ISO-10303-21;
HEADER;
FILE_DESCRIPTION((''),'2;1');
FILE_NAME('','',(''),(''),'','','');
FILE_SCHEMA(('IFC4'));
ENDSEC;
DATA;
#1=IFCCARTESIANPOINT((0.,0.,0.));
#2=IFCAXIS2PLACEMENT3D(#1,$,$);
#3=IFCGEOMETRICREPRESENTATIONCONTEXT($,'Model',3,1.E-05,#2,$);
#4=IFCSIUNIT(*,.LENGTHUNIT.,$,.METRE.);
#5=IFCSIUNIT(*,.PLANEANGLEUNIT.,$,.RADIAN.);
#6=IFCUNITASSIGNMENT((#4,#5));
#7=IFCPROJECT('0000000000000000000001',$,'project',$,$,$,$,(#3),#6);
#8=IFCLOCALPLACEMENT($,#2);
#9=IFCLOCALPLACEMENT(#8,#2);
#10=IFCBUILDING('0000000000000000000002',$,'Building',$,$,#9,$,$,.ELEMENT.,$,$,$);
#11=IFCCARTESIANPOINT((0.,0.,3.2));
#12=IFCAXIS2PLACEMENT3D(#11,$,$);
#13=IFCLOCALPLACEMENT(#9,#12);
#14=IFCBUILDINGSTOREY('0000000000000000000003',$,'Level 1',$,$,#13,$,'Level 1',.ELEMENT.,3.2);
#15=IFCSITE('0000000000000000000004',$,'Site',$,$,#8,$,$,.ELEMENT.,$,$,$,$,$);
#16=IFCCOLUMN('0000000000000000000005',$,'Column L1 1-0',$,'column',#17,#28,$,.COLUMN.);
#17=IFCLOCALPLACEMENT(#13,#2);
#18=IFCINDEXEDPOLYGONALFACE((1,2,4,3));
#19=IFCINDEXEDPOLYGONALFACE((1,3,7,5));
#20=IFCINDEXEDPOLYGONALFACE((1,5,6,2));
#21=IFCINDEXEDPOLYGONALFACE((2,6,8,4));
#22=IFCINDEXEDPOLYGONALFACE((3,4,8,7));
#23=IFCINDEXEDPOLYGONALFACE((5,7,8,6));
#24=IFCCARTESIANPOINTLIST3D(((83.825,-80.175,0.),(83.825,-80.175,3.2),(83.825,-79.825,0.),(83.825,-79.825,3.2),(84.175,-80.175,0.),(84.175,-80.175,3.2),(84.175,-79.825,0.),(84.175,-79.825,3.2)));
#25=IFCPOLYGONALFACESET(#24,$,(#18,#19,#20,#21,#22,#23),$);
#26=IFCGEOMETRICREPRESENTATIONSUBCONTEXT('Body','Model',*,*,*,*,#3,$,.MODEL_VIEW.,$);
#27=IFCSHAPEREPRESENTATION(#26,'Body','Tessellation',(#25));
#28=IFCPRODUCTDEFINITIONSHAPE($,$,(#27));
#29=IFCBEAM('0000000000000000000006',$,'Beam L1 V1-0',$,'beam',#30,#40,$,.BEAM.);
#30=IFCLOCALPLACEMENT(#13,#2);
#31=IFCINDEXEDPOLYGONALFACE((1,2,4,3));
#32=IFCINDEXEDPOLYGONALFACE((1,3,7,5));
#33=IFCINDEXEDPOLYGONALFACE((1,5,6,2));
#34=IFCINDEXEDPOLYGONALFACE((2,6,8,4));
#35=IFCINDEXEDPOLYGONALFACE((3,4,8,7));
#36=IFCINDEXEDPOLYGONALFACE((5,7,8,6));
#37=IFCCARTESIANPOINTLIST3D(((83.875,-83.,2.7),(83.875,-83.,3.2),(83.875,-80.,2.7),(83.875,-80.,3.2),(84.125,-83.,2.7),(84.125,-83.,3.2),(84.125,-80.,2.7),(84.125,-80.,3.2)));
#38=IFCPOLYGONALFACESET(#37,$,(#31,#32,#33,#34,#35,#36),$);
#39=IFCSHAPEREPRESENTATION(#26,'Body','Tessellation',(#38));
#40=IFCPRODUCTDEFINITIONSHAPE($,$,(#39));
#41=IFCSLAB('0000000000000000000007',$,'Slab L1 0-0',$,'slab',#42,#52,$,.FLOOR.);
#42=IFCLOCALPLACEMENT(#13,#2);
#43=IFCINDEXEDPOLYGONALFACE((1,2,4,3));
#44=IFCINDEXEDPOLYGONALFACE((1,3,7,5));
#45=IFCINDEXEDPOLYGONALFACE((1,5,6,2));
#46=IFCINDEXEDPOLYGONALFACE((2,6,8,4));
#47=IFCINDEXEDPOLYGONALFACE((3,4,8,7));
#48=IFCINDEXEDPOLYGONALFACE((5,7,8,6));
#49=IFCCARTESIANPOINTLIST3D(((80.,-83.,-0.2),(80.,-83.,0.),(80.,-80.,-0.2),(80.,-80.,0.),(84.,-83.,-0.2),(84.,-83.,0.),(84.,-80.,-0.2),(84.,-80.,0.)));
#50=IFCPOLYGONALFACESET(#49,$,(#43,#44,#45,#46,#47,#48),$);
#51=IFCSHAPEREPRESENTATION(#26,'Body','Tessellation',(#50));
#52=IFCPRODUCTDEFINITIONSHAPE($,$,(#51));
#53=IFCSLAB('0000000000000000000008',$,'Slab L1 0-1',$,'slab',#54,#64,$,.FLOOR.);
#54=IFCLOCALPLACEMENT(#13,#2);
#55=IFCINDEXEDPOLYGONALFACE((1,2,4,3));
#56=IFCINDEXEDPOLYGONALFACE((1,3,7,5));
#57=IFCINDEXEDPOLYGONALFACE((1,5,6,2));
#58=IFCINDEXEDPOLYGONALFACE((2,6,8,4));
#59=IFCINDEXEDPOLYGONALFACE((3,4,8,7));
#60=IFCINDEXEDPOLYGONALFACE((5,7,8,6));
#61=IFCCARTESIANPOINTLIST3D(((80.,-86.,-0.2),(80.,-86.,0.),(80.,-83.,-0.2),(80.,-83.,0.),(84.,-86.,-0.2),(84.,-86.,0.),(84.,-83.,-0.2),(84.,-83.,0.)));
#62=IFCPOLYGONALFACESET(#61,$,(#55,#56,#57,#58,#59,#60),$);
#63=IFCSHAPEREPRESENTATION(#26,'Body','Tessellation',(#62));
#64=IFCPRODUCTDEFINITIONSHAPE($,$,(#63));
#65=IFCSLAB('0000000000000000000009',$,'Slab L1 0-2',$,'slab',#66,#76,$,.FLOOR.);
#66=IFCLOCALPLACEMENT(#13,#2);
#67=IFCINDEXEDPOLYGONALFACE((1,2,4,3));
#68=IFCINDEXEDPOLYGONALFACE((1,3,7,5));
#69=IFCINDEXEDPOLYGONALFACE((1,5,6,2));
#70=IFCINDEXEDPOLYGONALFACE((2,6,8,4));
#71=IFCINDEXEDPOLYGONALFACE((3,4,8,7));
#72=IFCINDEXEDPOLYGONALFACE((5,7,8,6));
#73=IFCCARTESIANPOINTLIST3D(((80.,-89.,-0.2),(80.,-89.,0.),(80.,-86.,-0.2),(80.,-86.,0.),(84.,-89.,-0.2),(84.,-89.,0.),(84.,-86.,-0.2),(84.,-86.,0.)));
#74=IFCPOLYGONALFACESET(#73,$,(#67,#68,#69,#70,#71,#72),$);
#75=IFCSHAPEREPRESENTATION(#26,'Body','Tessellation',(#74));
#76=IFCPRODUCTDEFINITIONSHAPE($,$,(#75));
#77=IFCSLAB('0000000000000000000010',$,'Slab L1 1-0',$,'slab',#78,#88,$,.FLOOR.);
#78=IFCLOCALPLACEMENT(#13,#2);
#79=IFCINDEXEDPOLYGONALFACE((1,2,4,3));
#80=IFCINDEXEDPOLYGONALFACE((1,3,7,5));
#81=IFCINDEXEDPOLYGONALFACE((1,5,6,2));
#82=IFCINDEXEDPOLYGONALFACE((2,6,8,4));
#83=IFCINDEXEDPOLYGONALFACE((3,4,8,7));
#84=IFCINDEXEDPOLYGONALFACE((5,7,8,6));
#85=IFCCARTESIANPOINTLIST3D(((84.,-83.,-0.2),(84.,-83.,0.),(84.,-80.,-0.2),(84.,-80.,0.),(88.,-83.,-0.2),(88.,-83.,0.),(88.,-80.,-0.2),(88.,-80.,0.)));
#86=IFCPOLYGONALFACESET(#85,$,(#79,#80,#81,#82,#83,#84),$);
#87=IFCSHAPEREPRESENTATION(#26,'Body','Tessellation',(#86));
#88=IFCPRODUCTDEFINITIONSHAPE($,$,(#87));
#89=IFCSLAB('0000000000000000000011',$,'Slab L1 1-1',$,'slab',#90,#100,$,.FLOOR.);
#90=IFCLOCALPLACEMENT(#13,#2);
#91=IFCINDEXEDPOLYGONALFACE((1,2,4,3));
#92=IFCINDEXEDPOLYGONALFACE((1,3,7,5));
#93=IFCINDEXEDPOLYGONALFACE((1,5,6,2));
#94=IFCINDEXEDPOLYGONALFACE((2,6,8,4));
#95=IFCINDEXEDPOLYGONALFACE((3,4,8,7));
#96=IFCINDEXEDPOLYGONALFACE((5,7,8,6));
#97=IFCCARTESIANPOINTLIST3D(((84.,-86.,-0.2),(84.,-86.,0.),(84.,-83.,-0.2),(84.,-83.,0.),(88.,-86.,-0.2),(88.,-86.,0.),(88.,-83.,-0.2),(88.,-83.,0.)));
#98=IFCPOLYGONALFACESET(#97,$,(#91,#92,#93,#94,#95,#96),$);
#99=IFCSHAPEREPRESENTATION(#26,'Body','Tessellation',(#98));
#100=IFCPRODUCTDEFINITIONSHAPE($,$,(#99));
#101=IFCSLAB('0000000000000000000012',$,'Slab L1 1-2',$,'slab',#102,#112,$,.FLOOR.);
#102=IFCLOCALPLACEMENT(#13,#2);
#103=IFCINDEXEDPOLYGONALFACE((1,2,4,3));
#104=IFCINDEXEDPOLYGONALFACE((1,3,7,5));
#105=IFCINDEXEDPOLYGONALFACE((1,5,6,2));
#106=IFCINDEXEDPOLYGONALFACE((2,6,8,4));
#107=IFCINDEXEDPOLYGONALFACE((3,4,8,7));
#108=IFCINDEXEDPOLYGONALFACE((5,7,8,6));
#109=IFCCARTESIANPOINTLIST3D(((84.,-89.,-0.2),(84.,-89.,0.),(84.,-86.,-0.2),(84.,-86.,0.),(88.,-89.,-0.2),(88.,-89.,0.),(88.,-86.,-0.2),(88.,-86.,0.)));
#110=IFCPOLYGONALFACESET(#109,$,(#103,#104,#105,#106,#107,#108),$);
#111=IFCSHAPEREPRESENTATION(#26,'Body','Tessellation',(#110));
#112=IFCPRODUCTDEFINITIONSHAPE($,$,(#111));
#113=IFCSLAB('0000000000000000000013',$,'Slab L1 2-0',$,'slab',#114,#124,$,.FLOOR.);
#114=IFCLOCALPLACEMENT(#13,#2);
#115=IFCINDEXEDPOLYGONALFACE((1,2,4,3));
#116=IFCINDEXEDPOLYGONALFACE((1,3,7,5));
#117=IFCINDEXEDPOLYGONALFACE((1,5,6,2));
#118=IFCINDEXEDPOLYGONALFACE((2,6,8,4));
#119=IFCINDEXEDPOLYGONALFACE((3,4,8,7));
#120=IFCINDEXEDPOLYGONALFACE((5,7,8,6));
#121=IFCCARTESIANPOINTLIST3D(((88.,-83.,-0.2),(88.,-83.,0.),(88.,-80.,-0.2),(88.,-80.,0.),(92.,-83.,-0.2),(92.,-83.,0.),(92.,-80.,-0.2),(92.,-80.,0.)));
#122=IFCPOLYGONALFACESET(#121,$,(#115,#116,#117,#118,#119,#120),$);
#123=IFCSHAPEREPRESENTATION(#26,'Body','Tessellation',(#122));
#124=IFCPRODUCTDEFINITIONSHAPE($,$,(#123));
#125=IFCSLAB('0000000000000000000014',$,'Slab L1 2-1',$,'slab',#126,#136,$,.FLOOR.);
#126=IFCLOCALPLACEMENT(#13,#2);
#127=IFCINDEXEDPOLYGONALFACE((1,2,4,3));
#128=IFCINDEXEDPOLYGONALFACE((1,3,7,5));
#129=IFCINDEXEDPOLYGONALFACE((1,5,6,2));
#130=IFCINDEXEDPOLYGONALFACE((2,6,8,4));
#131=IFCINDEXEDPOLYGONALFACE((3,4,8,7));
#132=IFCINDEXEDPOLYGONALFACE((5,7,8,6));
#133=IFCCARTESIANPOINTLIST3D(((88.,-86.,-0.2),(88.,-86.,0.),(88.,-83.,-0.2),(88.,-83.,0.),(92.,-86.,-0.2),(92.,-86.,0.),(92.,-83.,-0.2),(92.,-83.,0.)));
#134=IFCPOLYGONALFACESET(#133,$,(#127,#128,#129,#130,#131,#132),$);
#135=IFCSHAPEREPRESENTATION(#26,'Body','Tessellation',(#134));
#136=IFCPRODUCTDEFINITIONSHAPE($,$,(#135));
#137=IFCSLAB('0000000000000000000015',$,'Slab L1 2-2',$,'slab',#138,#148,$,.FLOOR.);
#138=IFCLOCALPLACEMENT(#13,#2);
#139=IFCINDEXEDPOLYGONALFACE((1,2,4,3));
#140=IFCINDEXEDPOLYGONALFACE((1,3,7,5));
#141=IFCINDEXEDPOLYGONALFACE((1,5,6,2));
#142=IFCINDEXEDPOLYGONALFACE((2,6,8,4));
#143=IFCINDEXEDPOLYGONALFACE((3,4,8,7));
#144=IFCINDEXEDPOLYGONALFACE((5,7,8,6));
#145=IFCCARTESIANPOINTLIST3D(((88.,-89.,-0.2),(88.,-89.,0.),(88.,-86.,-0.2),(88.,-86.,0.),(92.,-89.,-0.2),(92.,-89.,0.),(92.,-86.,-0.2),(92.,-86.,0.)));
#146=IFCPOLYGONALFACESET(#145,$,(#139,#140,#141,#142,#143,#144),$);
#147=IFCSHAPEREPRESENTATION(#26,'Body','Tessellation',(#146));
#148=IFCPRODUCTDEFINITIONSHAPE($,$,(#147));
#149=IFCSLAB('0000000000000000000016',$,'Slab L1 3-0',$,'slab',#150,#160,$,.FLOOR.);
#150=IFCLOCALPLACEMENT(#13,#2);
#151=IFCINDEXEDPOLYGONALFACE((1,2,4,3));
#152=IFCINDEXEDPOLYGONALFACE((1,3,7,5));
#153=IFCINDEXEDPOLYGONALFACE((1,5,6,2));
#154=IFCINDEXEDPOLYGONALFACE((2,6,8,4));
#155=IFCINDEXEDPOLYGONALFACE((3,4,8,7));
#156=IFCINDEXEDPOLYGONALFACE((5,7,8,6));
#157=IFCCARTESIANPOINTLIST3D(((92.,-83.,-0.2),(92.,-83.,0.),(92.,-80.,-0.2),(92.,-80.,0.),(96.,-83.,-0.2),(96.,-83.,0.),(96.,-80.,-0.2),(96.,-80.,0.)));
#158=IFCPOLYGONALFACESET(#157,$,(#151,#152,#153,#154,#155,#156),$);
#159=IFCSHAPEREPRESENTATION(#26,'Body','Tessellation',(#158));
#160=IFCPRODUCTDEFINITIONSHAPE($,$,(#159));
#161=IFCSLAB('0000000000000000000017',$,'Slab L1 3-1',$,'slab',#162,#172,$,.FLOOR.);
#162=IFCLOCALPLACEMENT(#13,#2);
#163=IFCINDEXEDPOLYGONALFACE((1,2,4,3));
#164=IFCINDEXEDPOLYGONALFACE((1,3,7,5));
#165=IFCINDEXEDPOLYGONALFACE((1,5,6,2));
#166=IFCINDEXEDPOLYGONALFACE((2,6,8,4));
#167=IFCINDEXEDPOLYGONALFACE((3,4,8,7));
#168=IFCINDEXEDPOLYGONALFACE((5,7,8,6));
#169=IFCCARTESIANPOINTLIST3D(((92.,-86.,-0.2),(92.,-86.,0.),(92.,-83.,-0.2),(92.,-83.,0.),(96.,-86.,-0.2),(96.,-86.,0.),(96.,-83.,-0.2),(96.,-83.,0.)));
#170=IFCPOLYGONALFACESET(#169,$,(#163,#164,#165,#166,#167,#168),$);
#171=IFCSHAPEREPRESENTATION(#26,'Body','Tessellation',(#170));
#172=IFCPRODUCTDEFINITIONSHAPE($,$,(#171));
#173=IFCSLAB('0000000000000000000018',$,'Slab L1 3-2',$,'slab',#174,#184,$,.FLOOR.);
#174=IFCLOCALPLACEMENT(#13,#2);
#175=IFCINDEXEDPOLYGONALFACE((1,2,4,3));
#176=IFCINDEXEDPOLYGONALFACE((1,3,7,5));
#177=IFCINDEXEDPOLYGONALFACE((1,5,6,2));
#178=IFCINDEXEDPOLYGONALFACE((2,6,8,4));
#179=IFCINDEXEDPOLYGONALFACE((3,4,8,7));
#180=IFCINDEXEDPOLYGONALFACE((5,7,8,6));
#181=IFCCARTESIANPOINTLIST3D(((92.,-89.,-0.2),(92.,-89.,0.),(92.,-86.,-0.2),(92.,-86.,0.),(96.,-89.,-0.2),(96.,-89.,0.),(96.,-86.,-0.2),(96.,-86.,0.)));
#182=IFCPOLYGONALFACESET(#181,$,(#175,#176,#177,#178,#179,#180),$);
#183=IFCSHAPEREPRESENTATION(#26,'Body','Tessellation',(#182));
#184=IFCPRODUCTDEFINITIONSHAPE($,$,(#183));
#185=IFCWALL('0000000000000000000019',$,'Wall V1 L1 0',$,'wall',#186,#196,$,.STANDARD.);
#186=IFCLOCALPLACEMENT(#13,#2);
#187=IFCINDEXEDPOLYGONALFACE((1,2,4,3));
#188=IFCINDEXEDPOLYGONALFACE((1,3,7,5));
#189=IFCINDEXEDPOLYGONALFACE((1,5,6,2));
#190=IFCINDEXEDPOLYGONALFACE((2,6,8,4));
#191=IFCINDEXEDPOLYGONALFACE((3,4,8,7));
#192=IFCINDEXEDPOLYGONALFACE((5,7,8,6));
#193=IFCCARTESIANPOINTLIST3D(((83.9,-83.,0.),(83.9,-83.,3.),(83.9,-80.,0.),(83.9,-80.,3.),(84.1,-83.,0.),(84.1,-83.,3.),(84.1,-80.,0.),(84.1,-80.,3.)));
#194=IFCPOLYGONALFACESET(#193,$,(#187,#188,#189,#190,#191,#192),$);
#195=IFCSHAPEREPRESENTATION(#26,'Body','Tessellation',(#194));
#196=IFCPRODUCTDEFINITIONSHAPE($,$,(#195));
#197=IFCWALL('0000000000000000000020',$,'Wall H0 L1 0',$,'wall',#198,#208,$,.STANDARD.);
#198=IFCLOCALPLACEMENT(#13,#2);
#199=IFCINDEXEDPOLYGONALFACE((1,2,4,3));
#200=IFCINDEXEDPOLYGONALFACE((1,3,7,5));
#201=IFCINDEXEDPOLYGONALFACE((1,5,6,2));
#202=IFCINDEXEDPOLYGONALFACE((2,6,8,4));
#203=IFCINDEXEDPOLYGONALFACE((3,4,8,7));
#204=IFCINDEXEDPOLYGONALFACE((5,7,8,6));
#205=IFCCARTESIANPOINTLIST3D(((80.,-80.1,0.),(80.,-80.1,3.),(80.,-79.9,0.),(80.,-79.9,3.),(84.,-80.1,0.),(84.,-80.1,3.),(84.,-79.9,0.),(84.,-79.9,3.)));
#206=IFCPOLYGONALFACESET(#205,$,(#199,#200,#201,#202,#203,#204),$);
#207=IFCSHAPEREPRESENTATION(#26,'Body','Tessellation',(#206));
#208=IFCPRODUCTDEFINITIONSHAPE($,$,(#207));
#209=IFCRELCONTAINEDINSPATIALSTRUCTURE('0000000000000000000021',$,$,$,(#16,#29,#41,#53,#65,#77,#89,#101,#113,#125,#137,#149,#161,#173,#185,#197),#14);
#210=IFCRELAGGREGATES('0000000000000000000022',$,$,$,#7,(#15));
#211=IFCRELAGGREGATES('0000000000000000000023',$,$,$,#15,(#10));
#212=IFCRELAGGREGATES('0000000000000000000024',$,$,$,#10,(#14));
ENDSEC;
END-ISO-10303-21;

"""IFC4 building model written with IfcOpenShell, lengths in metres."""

from ifc_helpers import new_model, si_unit, frame, frame_2d, origin, origin_2d, place, context, subcontext, project, spatial, polyline, rectangle, outline, extrude, element, save


model = new_model("IFC4")

# Units and contexts
model_context = context("Model", 3, precision=1e-05, world=origin())
body_context = subcontext(model_context, "Body", "Model", "MODEL_VIEW")
ifc_project = project(units=[si_unit("LENGTHUNIT", "METRE"), si_unit("PLANEANGLEUNIT", "RADIAN")], contexts=[model_context])

# Site, building, storey
site_placement = place(None, origin())
site = spatial("IfcSite", under=ifc_project, at=site_placement, Name="Site", CompositionType="ELEMENT")
building_placement = place(site_placement, origin())
building = spatial("IfcBuilding", under=site, at=building_placement, Name="Building", CompositionType="ELEMENT")
storey_placement = place(building_placement, frame((0.0, 0.0, 3.2)))
storey = spatial("IfcBuildingStorey", under=building, at=storey_placement, Name="Level 1", LongName="Level 1", CompositionType="ELEMENT", Elevation=3.2)

# Column
column_placement = place(storey_placement, frame((84.0, -80.0, 0.0)))
element("IfcColumn", 1, at=column_placement, inside=storey, Name="Column L1 1-0", ObjectType="column", PredefinedType="COLUMN", context=body_context, shape_type="SweptSolid", body=[
    extrude(rectangle(XDim=0.35, YDim=0.35, at=origin_2d()), origin(), (0.0, 0.0, 1.0), 3.2),
])

# Beam
beam_placement = place(storey_placement, frame((84.0, -80.0, 2.95), z_axis=(0.0, -1.0, 0.0), x_axis=(0.0, 0.0, 1.0)))
element("IfcBeam", 2, at=beam_placement, inside=storey, Name="Beam L1 V1-0", ObjectType="beam", PredefinedType="BEAM", context=body_context, shape_type="SweptSolid", body=[
    extrude(rectangle(XDim=0.5, YDim=0.25, at=origin_2d()), origin(), (0.0, 0.0, 1.0), 3.0),
])

# Slabs
slab_1_placement = place(storey_placement, frame((0.0, 0.0, -0.2)))
element("IfcSlab", 3, at=slab_1_placement, inside=storey, Name="Slab L1 0-0", ObjectType="slab", PredefinedType="FLOOR", context=body_context, shape_type="SweptSolid", body=[
    extrude(outline(polyline([(80.0, -83.0), (84.0, -83.0), (84.0, -80.0), (80.0, -80.0), (80.0, -83.0)])), origin(), (0.0, 0.0, 1.0), 0.2),
])
slab_2_placement = place(storey_placement, frame((0.0, 0.0, -0.2)))
element("IfcSlab", 4, at=slab_2_placement, inside=storey, Name="Slab L1 0-1", ObjectType="slab", PredefinedType="FLOOR", context=body_context, shape_type="SweptSolid", body=[
    extrude(outline(polyline([(80.0, -86.0), (84.0, -86.0), (84.0, -83.0), (80.0, -83.0), (80.0, -86.0)])), origin(), (0.0, 0.0, 1.0), 0.2),
])
slab_3_placement = place(storey_placement, frame((0.0, 0.0, -0.2)))
element("IfcSlab", 5, at=slab_3_placement, inside=storey, Name="Slab L1 0-2", ObjectType="slab", PredefinedType="FLOOR", context=body_context, shape_type="SweptSolid", body=[
    extrude(outline(polyline([(80.0, -89.0), (84.0, -89.0), (84.0, -86.0), (80.0, -86.0), (80.0, -89.0)])), origin(), (0.0, 0.0, 1.0), 0.2),
])
slab_4_placement = place(storey_placement, frame((0.0, 0.0, -0.2)))
element("IfcSlab", 6, at=slab_4_placement, inside=storey, Name="Slab L1 1-0", ObjectType="slab", PredefinedType="FLOOR", context=body_context, shape_type="SweptSolid", body=[
    extrude(outline(polyline([(84.0, -83.0), (88.0, -83.0), (88.0, -80.0), (84.0, -80.0), (84.0, -83.0)])), origin(), (0.0, 0.0, 1.0), 0.2),
])
slab_5_placement = place(storey_placement, frame((0.0, 0.0, -0.2)))
element("IfcSlab", 7, at=slab_5_placement, inside=storey, Name="Slab L1 1-1", ObjectType="slab", PredefinedType="FLOOR", context=body_context, shape_type="SweptSolid", body=[
    extrude(outline(polyline([(84.0, -86.0), (88.0, -86.0), (88.0, -83.0), (84.0, -83.0), (84.0, -86.0)])), origin(), (0.0, 0.0, 1.0), 0.2),
])
slab_6_placement = place(storey_placement, frame((0.0, 0.0, -0.2)))
element("IfcSlab", 8, at=slab_6_placement, inside=storey, Name="Slab L1 1-2", ObjectType="slab", PredefinedType="FLOOR", context=body_context, shape_type="SweptSolid", body=[
    extrude(outline(polyline([(84.0, -89.0), (88.0, -89.0), (88.0, -86.0), (84.0, -86.0), (84.0, -89.0)])), origin(), (0.0, 0.0, 1.0), 0.2),
])
slab_7_placement = place(storey_placement, frame((0.0, 0.0, -0.2)))
element("IfcSlab", 9, at=slab_7_placement, inside=storey, Name="Slab L1 2-0", ObjectType="slab", PredefinedType="FLOOR", context=body_context, shape_type="SweptSolid", body=[
    extrude(outline(polyline([(88.0, -83.0), (92.0, -83.0), (92.0, -80.0), (88.0, -80.0), (88.0, -83.0)])), origin(), (0.0, 0.0, 1.0), 0.2),
])
slab_8_placement = place(storey_placement, frame((0.0, 0.0, -0.2)))
element("IfcSlab", 10, at=slab_8_placement, inside=storey, Name="Slab L1 2-1", ObjectType="slab", PredefinedType="FLOOR", context=body_context, shape_type="SweptSolid", body=[
    extrude(outline(polyline([(88.0, -86.0), (92.0, -86.0), (92.0, -83.0), (88.0, -83.0), (88.0, -86.0)])), origin(), (0.0, 0.0, 1.0), 0.2),
])
slab_9_placement = place(storey_placement, frame((0.0, 0.0, -0.2)))
element("IfcSlab", 11, at=slab_9_placement, inside=storey, Name="Slab L1 2-2", ObjectType="slab", PredefinedType="FLOOR", context=body_context, shape_type="SweptSolid", body=[
    extrude(outline(polyline([(88.0, -89.0), (92.0, -89.0), (92.0, -86.0), (88.0, -86.0), (88.0, -89.0)])), origin(), (0.0, 0.0, 1.0), 0.2),
])
slab_10_placement = place(storey_placement, frame((0.0, 0.0, -0.2)))
element("IfcSlab", 12, at=slab_10_placement, inside=storey, Name="Slab L1 3-0", ObjectType="slab", PredefinedType="FLOOR", context=body_context, shape_type="SweptSolid", body=[
    extrude(outline(polyline([(92.0, -83.0), (96.0, -83.0), (96.0, -80.0), (92.0, -80.0), (92.0, -83.0)])), origin(), (0.0, 0.0, 1.0), 0.2),
])
slab_11_placement = place(storey_placement, frame((0.0, 0.0, -0.2)))
element("IfcSlab", 13, at=slab_11_placement, inside=storey, Name="Slab L1 3-1", ObjectType="slab", PredefinedType="FLOOR", context=body_context, shape_type="SweptSolid", body=[
    extrude(outline(polyline([(92.0, -86.0), (96.0, -86.0), (96.0, -83.0), (92.0, -83.0), (92.0, -86.0)])), origin(), (0.0, 0.0, 1.0), 0.2),
])
slab_12_placement = place(storey_placement, frame((0.0, 0.0, -0.2)))
element("IfcSlab", 14, at=slab_12_placement, inside=storey, Name="Slab L1 3-2", ObjectType="slab", PredefinedType="FLOOR", context=body_context, shape_type="SweptSolid", body=[
    extrude(outline(polyline([(92.0, -89.0), (96.0, -89.0), (96.0, -86.0), (92.0, -86.0), (92.0, -89.0)])), origin(), (0.0, 0.0, 1.0), 0.2),
])

# Walls
wall_1_placement = place(storey_placement, frame((84.0, -80.0, 0.0), z_axis=(0.0, 0.0, 1.0), x_axis=(0.0, -1.0, 0.0)))
element("IfcWall", 15, at=wall_1_placement, inside=storey, Name="Wall V1 L1 0", ObjectType="wall", PredefinedType="STANDARD", context=body_context, shape_type="SweptSolid", body=[
    extrude(rectangle(XDim=3.0, YDim=0.2, at=frame_2d((1.5, 0.0))), origin(), (0.0, 0.0, 1.0), 3.0),
])
wall_2_placement = place(storey_placement, frame((80.0, -80.0, 0.0), z_axis=(0.0, 0.0, 1.0), x_axis=(1.0, 0.0, 0.0)))
element("IfcWall", 16, at=wall_2_placement, inside=storey, Name="Wall H0 L1 0", ObjectType="wall", PredefinedType="STANDARD", context=body_context, shape_type="SweptSolid", body=[
    extrude(rectangle(XDim=4.0, YDim=0.2, at=frame_2d((2.0, 0.0))), origin(), (0.0, 0.0, 1.0), 3.0),
])

save(model, "model.ifc")
